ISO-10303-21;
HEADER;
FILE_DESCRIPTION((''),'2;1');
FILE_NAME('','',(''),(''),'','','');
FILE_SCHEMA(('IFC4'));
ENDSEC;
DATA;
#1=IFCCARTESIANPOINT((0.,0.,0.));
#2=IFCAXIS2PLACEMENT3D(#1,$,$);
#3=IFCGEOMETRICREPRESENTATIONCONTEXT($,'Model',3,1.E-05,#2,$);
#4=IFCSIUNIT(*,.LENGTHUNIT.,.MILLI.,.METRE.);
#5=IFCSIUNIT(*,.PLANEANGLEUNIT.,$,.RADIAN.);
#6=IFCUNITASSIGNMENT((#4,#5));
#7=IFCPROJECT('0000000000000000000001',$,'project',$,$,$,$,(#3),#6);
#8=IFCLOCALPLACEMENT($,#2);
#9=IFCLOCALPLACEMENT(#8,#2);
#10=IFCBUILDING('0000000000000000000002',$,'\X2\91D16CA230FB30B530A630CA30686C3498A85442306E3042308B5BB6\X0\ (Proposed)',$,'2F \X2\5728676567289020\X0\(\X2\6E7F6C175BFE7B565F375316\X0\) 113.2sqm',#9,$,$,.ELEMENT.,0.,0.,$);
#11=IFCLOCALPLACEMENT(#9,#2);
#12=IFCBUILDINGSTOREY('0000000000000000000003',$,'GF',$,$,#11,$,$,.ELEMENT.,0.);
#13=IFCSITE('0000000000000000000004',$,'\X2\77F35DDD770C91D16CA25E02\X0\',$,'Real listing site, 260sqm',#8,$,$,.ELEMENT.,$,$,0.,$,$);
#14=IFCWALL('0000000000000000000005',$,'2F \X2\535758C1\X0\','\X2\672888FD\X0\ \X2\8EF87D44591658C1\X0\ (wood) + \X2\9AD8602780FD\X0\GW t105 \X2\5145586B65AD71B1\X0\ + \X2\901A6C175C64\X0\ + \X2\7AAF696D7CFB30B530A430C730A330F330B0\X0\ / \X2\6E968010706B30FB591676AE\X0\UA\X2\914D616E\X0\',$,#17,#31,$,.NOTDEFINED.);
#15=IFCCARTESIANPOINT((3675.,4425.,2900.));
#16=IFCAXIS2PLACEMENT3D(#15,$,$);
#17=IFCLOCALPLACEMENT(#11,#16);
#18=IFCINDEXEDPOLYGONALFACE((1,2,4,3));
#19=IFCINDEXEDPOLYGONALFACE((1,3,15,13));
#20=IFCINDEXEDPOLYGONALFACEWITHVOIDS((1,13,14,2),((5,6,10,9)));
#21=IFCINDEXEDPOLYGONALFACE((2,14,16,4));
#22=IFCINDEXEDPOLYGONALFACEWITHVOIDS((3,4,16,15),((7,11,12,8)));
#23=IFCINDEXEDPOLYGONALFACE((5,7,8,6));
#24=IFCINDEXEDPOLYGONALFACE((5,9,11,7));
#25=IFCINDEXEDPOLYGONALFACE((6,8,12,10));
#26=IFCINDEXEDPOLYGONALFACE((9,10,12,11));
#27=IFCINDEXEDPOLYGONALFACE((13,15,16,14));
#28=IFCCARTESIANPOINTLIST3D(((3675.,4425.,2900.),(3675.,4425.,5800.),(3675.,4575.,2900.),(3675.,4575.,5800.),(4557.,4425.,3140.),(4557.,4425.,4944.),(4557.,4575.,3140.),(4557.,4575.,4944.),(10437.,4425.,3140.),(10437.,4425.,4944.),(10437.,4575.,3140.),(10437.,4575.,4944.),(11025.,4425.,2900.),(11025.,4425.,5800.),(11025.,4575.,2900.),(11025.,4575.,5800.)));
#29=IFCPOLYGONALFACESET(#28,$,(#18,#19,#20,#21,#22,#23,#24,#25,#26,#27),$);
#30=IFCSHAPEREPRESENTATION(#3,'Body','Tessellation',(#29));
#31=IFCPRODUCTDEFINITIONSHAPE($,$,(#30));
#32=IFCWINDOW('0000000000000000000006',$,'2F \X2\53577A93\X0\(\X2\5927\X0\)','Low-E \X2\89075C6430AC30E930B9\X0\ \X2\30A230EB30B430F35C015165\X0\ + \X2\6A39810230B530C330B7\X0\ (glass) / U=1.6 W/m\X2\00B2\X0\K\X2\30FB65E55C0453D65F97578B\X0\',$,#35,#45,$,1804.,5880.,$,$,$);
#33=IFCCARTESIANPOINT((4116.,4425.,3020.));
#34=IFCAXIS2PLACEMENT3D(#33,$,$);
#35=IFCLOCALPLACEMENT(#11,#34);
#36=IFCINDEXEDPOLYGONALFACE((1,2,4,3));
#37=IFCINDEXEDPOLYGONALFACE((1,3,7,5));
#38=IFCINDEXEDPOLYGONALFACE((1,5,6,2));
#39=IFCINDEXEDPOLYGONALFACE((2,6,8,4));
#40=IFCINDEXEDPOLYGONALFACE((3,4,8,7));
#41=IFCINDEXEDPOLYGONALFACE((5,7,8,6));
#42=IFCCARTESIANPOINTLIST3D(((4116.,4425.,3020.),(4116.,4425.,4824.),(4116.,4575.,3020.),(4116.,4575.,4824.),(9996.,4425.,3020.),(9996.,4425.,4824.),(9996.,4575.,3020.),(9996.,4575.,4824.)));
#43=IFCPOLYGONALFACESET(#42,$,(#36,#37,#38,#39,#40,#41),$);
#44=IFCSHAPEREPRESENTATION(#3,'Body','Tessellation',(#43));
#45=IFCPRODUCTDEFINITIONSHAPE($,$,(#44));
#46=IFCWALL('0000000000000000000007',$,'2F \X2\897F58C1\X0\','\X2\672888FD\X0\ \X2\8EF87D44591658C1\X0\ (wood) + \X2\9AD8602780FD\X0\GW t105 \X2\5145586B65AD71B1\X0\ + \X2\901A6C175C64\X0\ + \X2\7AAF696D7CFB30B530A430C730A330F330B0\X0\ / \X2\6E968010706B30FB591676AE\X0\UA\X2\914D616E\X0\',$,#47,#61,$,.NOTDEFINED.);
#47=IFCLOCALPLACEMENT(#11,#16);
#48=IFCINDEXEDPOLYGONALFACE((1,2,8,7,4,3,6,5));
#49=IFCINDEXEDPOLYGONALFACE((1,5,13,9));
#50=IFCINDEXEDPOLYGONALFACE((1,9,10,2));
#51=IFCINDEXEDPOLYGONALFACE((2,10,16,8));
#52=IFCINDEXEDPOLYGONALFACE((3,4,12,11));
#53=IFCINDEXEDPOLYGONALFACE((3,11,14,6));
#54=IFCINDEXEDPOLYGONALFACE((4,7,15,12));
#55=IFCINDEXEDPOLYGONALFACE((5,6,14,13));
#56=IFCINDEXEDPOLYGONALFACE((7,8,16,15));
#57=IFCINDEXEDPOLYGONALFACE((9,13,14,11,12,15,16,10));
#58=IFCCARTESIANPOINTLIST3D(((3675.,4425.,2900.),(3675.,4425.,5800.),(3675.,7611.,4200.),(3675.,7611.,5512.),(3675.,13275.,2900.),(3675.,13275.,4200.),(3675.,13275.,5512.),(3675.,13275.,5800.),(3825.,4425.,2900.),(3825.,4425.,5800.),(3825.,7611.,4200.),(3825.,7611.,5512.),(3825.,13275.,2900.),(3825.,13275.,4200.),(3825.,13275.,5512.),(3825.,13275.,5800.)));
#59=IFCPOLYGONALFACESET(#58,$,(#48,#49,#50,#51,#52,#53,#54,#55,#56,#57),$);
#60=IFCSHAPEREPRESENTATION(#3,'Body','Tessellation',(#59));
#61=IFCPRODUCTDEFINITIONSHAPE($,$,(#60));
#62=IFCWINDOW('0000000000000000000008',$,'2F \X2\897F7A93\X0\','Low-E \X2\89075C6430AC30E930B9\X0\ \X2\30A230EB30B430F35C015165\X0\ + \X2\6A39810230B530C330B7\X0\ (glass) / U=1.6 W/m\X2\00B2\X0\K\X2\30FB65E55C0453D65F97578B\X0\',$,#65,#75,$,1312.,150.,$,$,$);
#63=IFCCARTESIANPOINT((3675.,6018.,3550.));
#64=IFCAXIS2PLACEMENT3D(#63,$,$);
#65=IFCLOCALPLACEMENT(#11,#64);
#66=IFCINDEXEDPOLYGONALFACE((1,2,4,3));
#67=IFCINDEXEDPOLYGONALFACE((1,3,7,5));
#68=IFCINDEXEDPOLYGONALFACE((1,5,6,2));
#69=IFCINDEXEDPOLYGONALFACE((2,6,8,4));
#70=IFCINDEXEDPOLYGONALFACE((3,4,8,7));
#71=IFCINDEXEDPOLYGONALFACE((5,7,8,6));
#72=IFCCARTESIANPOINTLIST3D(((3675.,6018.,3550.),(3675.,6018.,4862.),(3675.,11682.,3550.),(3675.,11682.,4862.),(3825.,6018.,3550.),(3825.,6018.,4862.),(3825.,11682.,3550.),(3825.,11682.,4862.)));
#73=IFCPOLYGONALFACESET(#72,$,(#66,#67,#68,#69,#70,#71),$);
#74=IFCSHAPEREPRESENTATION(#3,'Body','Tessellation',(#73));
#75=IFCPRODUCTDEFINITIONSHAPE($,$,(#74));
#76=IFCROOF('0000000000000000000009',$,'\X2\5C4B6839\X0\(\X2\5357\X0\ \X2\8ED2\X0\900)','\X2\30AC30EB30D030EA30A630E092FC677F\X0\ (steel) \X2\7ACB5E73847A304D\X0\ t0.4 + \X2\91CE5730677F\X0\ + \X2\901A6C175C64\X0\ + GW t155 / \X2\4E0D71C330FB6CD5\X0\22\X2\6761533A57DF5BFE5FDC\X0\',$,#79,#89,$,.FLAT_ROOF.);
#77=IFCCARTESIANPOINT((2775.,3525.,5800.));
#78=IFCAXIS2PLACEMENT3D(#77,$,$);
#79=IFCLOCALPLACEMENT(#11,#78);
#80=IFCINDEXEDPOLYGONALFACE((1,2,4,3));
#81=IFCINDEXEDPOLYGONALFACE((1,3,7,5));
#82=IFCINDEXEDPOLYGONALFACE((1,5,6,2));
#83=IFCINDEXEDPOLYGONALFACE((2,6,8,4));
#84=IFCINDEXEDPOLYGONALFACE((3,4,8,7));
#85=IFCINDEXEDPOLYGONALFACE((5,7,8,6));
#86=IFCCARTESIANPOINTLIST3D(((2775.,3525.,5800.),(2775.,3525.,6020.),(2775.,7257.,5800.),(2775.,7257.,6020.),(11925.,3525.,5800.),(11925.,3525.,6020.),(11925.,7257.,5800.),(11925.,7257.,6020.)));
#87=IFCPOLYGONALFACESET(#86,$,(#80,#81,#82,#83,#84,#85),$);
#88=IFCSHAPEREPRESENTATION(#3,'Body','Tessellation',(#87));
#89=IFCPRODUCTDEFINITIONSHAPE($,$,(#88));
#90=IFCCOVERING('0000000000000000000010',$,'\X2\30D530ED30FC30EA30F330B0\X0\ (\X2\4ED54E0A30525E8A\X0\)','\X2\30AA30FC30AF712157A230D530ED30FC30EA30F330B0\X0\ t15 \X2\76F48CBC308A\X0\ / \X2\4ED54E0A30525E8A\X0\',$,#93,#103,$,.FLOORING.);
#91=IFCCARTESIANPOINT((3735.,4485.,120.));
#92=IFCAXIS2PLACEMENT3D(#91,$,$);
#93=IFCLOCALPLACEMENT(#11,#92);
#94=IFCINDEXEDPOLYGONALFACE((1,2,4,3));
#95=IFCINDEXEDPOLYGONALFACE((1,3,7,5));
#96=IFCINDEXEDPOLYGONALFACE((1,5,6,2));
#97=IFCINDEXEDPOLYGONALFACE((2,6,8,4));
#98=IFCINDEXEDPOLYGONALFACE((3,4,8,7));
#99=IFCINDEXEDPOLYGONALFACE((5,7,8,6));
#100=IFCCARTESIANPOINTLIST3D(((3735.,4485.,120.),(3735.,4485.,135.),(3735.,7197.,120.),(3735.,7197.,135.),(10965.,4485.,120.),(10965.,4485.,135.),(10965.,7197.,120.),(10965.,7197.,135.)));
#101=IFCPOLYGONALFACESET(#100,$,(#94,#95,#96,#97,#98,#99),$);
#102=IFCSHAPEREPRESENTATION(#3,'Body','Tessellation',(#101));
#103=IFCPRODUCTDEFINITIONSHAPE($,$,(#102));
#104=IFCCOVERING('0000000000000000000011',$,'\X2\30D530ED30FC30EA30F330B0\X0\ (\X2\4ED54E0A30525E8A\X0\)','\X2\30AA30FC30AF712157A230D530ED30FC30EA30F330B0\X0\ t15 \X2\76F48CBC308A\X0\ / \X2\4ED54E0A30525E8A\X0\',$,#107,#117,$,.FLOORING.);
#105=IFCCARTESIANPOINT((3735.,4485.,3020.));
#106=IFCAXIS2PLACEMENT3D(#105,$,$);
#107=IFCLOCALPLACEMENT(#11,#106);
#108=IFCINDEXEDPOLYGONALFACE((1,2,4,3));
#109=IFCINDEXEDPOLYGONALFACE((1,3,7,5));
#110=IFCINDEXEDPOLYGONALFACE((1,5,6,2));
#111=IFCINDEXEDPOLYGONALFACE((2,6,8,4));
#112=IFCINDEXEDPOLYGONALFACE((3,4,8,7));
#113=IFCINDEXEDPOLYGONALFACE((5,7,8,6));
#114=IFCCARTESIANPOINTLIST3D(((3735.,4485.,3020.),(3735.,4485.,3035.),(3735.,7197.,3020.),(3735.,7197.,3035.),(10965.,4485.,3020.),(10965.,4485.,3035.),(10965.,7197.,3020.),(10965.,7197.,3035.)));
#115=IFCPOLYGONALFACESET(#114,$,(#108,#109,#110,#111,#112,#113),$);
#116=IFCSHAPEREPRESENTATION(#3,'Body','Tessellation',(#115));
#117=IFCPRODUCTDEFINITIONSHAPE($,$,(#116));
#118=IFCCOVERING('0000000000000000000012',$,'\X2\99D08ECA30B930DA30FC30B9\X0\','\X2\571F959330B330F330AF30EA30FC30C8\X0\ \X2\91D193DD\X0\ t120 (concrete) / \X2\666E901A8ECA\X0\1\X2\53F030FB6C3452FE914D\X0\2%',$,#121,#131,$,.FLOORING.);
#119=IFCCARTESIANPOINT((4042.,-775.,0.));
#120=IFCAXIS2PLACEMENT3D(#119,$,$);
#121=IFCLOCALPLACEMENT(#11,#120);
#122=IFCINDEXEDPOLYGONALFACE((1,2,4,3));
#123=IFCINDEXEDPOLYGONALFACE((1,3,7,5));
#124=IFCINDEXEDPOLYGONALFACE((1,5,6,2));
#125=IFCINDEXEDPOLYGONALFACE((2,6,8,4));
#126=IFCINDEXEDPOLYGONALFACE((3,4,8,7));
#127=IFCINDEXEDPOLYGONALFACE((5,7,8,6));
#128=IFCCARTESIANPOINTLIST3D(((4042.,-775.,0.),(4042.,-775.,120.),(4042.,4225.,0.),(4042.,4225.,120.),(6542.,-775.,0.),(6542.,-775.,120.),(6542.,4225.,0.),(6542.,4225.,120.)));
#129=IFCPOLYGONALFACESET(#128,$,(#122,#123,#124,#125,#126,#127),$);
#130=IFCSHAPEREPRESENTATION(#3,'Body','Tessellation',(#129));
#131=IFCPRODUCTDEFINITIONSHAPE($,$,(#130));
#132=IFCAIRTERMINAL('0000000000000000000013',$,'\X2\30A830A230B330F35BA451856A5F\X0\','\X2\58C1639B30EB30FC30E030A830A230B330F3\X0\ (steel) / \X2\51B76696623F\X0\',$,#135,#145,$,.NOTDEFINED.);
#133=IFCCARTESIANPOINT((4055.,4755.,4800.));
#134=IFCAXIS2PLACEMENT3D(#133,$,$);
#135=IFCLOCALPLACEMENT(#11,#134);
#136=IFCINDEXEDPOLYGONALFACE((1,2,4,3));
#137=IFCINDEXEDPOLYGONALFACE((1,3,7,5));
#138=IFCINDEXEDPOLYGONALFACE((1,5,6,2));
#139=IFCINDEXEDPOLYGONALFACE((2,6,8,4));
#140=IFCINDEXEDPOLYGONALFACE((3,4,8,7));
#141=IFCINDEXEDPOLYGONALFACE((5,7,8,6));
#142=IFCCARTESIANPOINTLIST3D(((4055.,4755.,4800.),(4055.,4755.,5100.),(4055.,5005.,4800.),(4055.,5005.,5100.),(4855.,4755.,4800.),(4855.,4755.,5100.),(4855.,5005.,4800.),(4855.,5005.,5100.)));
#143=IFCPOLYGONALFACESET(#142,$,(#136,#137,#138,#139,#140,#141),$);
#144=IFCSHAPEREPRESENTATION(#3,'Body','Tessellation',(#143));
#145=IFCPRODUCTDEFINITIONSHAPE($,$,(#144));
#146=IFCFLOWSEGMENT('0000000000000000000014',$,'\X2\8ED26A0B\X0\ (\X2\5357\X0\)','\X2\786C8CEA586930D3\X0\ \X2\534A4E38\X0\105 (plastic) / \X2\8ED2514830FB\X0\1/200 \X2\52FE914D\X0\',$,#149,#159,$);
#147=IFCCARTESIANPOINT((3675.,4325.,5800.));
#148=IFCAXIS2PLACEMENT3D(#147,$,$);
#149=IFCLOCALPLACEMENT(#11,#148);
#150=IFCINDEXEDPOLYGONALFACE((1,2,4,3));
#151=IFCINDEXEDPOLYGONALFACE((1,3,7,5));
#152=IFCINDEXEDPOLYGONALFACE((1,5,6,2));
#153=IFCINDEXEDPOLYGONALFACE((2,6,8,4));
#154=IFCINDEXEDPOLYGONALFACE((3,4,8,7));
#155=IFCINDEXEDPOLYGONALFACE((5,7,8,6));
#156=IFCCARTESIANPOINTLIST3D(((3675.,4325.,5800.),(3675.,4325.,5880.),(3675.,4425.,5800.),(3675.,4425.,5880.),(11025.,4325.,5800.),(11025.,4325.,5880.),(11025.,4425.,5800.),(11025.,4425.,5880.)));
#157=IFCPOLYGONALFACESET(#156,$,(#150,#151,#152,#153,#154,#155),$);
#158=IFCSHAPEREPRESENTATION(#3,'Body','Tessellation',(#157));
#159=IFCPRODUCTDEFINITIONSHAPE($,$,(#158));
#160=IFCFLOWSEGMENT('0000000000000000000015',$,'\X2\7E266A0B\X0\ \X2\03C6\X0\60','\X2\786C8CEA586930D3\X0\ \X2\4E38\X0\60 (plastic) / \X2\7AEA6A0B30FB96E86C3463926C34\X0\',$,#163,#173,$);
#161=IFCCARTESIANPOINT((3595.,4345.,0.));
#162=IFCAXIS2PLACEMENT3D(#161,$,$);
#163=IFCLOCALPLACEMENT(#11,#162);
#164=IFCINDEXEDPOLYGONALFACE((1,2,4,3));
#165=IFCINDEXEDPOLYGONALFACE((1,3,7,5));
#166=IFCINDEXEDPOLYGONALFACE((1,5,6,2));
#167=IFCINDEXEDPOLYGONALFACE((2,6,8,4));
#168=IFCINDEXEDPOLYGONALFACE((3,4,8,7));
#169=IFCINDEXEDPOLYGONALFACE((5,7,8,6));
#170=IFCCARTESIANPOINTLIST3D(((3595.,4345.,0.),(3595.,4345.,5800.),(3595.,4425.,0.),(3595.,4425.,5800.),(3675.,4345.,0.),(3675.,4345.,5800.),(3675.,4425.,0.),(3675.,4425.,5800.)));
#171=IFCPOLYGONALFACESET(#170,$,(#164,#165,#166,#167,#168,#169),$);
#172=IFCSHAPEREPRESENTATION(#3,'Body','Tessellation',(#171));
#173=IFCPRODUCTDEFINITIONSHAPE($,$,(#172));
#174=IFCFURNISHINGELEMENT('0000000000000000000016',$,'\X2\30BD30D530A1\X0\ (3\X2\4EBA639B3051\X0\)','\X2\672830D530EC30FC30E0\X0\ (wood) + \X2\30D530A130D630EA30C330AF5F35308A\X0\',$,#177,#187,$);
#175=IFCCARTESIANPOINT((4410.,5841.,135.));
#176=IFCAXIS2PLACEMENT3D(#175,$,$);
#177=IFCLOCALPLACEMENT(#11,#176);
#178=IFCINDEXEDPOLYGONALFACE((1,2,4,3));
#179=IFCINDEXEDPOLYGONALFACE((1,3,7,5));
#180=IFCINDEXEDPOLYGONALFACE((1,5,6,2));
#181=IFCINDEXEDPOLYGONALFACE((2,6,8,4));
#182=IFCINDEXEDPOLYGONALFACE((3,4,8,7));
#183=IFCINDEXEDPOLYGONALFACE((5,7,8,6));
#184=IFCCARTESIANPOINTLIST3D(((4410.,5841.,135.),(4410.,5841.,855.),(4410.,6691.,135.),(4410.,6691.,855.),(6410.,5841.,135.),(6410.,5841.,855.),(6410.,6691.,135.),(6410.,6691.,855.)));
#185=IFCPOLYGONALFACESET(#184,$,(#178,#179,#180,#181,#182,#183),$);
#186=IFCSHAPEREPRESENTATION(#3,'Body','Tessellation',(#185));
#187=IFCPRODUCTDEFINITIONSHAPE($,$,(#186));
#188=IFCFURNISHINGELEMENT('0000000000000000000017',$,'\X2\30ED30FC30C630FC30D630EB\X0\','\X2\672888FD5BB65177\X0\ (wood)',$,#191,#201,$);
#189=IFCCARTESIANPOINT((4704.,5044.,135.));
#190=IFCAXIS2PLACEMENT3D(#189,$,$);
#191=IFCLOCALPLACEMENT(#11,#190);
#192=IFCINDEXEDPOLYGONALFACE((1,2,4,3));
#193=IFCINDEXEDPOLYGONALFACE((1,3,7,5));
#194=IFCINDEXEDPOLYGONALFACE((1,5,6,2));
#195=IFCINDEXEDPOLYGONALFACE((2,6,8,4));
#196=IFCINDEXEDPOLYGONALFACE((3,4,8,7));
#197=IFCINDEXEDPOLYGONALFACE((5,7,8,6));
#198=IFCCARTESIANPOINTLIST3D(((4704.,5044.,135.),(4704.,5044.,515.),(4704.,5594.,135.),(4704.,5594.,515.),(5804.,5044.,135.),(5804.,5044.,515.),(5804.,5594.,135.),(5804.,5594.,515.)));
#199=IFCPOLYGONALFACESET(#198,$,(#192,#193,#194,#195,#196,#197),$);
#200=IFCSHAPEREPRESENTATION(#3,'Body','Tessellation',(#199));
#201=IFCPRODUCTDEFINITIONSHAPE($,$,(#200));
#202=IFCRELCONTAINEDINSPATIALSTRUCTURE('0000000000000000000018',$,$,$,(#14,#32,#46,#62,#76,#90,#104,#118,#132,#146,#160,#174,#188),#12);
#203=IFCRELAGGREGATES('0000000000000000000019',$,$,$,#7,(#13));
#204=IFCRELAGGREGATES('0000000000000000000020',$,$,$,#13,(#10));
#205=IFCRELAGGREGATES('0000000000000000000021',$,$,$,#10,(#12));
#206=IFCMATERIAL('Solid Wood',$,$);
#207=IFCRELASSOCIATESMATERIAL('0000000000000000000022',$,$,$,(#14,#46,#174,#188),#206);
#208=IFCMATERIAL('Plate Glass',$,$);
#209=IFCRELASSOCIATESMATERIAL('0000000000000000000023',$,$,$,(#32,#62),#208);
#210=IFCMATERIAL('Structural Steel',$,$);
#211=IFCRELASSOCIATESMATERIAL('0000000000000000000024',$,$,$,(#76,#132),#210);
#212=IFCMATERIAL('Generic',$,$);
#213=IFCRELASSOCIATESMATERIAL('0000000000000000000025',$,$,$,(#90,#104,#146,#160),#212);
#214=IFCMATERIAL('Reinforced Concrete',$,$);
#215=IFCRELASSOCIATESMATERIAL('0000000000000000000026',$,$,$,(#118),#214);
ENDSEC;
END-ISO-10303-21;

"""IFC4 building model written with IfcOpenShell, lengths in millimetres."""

from ifc_helpers import new_model, si_unit, frame, frame_2d, origin, place, context, project, spatial, rectangle, extrude, material, element, fill, save


model = new_model("IFC4")

# Units and contexts
model_context = context("Model", 3, precision=1e-05, world=origin())
ifc_project = project(units=[si_unit("LENGTHUNIT", "METRE", prefix="MILLI"), si_unit("PLANEANGLEUNIT", "RADIAN")], contexts=[model_context])

# Site, building, storey
site_placement = place(None, origin())
site = spatial("IfcSite", under=ifc_project, at=site_placement, Name="石川県金沢市", ObjectType="Real listing site, 260sqm", CompositionType="ELEMENT", RefElevation=0.0)
building_placement = place(site_placement, origin())
building = spatial("IfcBuilding", under=site, at=building_placement, Name="金沢・サウナと水風呂のある家 (Proposed)", ObjectType="2F 在来木造(湿気対策強化) 113.2sqm", CompositionType="ELEMENT", ElevationOfRefHeight=0.0, ElevationOfTerrain=0.0)
storey_placement = place(building_placement, origin())
storey = spatial("IfcBuildingStorey", under=building, at=storey_placement, Name="GF", CompositionType="ELEMENT", Elevation=0.0)

# Shared definitions
ifc_material_1 = material(Name="Solid Wood")

# Shared definitions
ifc_material_2 = material(Name="Reinforced Concrete")

# Shared definitions
ifc_material_3 = material(Name="Plate Glass")

# Walls, openings, windows
wall_1_placement = place(storey_placement, frame((3675.0, 4425.0, 2900.0)))
wall_1 = element("IfcWall", 1, at=wall_1_placement, inside=storey, material=ifc_material_1, Name="2F 南壁", Description="木製 軸組外壁 (wood) + 高性能GW t105 充填断熱 + 通気層 + 窯業系サイディング / 準耐火・外皮UA配慮", PredefinedType="NOTDEFINED", context=model_context, shape_type="SweptSolid", body=[
    extrude(rectangle(XDim=7350.0, YDim=150.0, at=frame_2d((3675.0, 75.0))), frame((3675.0, 4425.0, 2900.0)), (0.0, 0.0, 1.0), 2900.0),
])
opening_1_placement = place(storey_placement, frame((4116.0, 4425.0, 3020.0)))
opening_1 = element("IfcOpeningElement", 2, at=opening_1_placement, cuts=wall_1, PredefinedType="NOTDEFINED", context=model_context, shape_type="SweptSolid", body=[
    extrude(rectangle(XDim=5880.0, YDim=150.0, at=frame_2d((2940.0, 75.0))), frame((4116.0, 4425.0, 3020.0)), (0.0, 0.0, 1.0), 1804.0),
])
window_1_placement = place(storey_placement, frame((4116.0, 4425.0, 3020.0)))
window_1 = element("IfcWindow", 3, at=window_1_placement, inside=storey, material=ifc_material_3, Name="2F 南窓(大)", Description="Low-E 複層ガラス アルゴン封入 + 樹脂サッシ (glass) / U=1.6 W/m²K・日射取得型", OverallHeight=1804.0, OverallWidth=5880.0, context=model_context, shape_type="SweptSolid", body=[
    extrude(rectangle(XDim=5880.0, YDim=150.0, at=frame_2d((2940.0, 75.0))), frame((4116.0, 4425.0, 3020.0)), (0.0, 0.0, 1.0), 1804.0),
])
fill(opening_1, window_1)
wall_2_placement = place(storey_placement, frame((3675.0, 4425.0, 2900.0)))
wall_2 = element("IfcWall", 4, at=wall_2_placement, inside=storey, material=ifc_material_1, Name="2F 西壁", Description="木製 軸組外壁 (wood) + 高性能GW t105 充填断熱 + 通気層 + 窯業系サイディング / 準耐火・外皮UA配慮", PredefinedType="NOTDEFINED", context=model_context, shape_type="SweptSolid", body=[
    extrude(rectangle(XDim=150.0, YDim=8850.0, at=frame_2d((75.0, 4425.0))), frame((3675.0, 4425.0, 2900.0)), (0.0, 0.0, 1.0), 2900.0),
])
opening_2_placement = place(storey_placement, frame((3675.0, 6018.0, 3550.0)))
opening_2 = element("IfcOpeningElement", 5, at=opening_2_placement, cuts=wall_2, PredefinedType="NOTDEFINED", context=model_context, shape_type="SweptSolid", body=[
    extrude(rectangle(XDim=150.0, YDim=5664.0, at=frame_2d((75.0, 2832.0))), frame((3675.0, 6018.0, 3550.0)), (0.0, 0.0, 1.0), 1312.0),
])
window_2_placement = place(storey_placement, frame((3675.0, 6018.0, 3550.0)))
window_2 = element("IfcWindow", 6, at=window_2_placement, inside=storey, material=ifc_material_3, Name="2F 西窓", Description="Low-E 複層ガラス アルゴン封入 + 樹脂サッシ (glass) / U=1.6 W/m²K・日射取得型", OverallHeight=1312.0, OverallWidth=150.0, context=model_context, shape_type="SweptSolid", body=[
    extrude(rectangle(XDim=150.0, YDim=5664.0, at=frame_2d((75.0, 2832.0))), frame((3675.0, 6018.0, 3550.0)), (0.0, 0.0, 1.0), 1312.0),
])
fill(opening_2, window_2)

# Roof
ifc_material_4 = material(Name="Structural Steel")
for number, where, name in (
    (7, (2775.0, 3525.0, 5800.0), "屋根(南 軒900)"),
):
    element("IfcRoof", number, at=place(storey_placement, frame(where)), inside=storey, material=ifc_material_4, Name=name, Description="ガルバリウム鋼板 (steel) 立平葺き t0.4 + 野地板 + 通気層 + GW t155 / 不燃・法22条区域対応", PredefinedType="FLAT_ROOF", context=model_context, shape_type="SweptSolid", body=[
        extrude(rectangle(XDim=9150.0, YDim=3732.0, at=frame_2d((4575.0, 1866.0))), frame((2775.0, 3525.0, 5800.0)), (0.0, 0.0, 1.0), 220.0),
    ])

# Coverings
ifc_material_5 = material(Name="Generic")
covering_1_placement = place(storey_placement, frame((3735.0, 4485.0, 120.0)))
element("IfcCovering", 8, at=covering_1_placement, inside=storey, material=ifc_material_5, Name="フローリング (仕上げ床)", Description="オーク無垢フローリング t15 直貼り / 仕上げ床", PredefinedType="FLOORING", context=model_context, shape_type="SweptSolid", body=[
    extrude(rectangle(XDim=7230.0, YDim=2712.0, at=frame_2d((3615.0, 1356.0))), frame((3735.0, 4485.0, 120.0)), (0.0, 0.0, 1.0), 15.0),
])
covering_2_placement = place(storey_placement, frame((3735.0, 4485.0, 3020.0)))
element("IfcCovering", 9, at=covering_2_placement, inside=storey, material=ifc_material_5, Name="フローリング (仕上げ床)", Description="オーク無垢フローリング t15 直貼り / 仕上げ床", PredefinedType="FLOORING", context=model_context, shape_type="SweptSolid", body=[
    extrude(rectangle(XDim=7230.0, YDim=2712.0, at=frame_2d((3615.0, 1356.0))), frame((3735.0, 4485.0, 3020.0)), (0.0, 0.0, 1.0), 15.0),
])
covering_3_placement = place(storey_placement, frame((4042.0, -775.0, 0.0)))
element("IfcCovering", 10, at=covering_3_placement, inside=storey, material=ifc_material_2, Name="駐車スペース", Description="土間コンクリート 金鏝 t120 (concrete) / 普通車1台・水勾配2%", PredefinedType="FLOORING", context=model_context, shape_type="SweptSolid", body=[
    extrude(rectangle(XDim=2500.0, YDim=5000.0, at=frame_2d((1250.0, 2500.0))), frame((4042.0, -775.0, 0.0)), (0.0, 0.0, 1.0), 120.0),
])

# Air terminal
air_terminal_placement = place(storey_placement, frame((4055.0, 4755.0, 4800.0)))
element("IfcAirTerminal", 11, at=air_terminal_placement, inside=storey, material=ifc_material_4, Name="エアコン室内機", Description="壁掛ルームエアコン (steel) / 冷暖房", PredefinedType="NOTDEFINED", context=model_context, shape_type="SweptSolid", body=[
    extrude(rectangle(XDim=800.0, YDim=250.0, at=frame_2d((400.0, 125.0))), frame((4055.0, 4755.0, 4800.0)), (0.0, 0.0, 1.0), 300.0),
])

# Flow segments
flow_segment_1_placement = place(storey_placement, frame((3675.0, 4325.0, 5800.0)))
element("IfcFlowSegment", 12, at=flow_segment_1_placement, inside=storey, material=ifc_material_5, Name="軒樋 (南)", Description="硬質塩ビ 半丸105 (plastic) / 軒先・1/200 勾配", context=model_context, shape_type="SweptSolid", body=[
    extrude(rectangle(XDim=7350.0, YDim=100.0, at=frame_2d((3675.0, 50.0))), frame((3675.0, 4325.0, 5800.0)), (0.0, 0.0, 1.0), 80.0),
])
flow_segment_2_placement = place(storey_placement, frame((3595.0, 4345.0, 0.0)))
element("IfcFlowSegment", 13, at=flow_segment_2_placement, inside=storey, material=ifc_material_5, Name="縦樋 φ60", Description="硬質塩ビ 丸60 (plastic) / 竪樋・雨水排水", context=model_context, shape_type="SweptSolid", body=[
    extrude(rectangle(XDim=80.0, YDim=80.0, at=frame_2d((40.0, 40.0))), frame((3595.0, 4345.0, 0.0)), (0.0, 0.0, 1.0), 5800.0),
])

# Furnishing elements
furnishing_1_placement = place(storey_placement, frame((4410.0, 5841.0, 135.0)))
element("IfcFurnishingElement", 14, at=furnishing_1_placement, inside=storey, material=ifc_material_1, Name="ソファ (3人掛け)", Description="木フレーム (wood) + ファブリック張り", context=model_context, shape_type="SweptSolid", body=[
    extrude(rectangle(XDim=2000.0, YDim=850.0, at=frame_2d((1000.0, 425.0))), frame((4410.0, 5841.0, 135.0)), (0.0, 0.0, 1.0), 720.0),
])
furnishing_2_placement = place(storey_placement, frame((4704.0, 5044.0, 135.0)))
element("IfcFurnishingElement", 15, at=furnishing_2_placement, inside=storey, material=ifc_material_1, Name="ローテーブル", Description="木製家具 (wood)", context=model_context, shape_type="SweptSolid", body=[
    extrude(rectangle(XDim=1100.0, YDim=550.0, at=frame_2d((550.0, 275.0))), frame((4704.0, 5044.0, 135.0)), (0.0, 0.0, 1.0), 380.0),
])

save(model, "model.ifc")
